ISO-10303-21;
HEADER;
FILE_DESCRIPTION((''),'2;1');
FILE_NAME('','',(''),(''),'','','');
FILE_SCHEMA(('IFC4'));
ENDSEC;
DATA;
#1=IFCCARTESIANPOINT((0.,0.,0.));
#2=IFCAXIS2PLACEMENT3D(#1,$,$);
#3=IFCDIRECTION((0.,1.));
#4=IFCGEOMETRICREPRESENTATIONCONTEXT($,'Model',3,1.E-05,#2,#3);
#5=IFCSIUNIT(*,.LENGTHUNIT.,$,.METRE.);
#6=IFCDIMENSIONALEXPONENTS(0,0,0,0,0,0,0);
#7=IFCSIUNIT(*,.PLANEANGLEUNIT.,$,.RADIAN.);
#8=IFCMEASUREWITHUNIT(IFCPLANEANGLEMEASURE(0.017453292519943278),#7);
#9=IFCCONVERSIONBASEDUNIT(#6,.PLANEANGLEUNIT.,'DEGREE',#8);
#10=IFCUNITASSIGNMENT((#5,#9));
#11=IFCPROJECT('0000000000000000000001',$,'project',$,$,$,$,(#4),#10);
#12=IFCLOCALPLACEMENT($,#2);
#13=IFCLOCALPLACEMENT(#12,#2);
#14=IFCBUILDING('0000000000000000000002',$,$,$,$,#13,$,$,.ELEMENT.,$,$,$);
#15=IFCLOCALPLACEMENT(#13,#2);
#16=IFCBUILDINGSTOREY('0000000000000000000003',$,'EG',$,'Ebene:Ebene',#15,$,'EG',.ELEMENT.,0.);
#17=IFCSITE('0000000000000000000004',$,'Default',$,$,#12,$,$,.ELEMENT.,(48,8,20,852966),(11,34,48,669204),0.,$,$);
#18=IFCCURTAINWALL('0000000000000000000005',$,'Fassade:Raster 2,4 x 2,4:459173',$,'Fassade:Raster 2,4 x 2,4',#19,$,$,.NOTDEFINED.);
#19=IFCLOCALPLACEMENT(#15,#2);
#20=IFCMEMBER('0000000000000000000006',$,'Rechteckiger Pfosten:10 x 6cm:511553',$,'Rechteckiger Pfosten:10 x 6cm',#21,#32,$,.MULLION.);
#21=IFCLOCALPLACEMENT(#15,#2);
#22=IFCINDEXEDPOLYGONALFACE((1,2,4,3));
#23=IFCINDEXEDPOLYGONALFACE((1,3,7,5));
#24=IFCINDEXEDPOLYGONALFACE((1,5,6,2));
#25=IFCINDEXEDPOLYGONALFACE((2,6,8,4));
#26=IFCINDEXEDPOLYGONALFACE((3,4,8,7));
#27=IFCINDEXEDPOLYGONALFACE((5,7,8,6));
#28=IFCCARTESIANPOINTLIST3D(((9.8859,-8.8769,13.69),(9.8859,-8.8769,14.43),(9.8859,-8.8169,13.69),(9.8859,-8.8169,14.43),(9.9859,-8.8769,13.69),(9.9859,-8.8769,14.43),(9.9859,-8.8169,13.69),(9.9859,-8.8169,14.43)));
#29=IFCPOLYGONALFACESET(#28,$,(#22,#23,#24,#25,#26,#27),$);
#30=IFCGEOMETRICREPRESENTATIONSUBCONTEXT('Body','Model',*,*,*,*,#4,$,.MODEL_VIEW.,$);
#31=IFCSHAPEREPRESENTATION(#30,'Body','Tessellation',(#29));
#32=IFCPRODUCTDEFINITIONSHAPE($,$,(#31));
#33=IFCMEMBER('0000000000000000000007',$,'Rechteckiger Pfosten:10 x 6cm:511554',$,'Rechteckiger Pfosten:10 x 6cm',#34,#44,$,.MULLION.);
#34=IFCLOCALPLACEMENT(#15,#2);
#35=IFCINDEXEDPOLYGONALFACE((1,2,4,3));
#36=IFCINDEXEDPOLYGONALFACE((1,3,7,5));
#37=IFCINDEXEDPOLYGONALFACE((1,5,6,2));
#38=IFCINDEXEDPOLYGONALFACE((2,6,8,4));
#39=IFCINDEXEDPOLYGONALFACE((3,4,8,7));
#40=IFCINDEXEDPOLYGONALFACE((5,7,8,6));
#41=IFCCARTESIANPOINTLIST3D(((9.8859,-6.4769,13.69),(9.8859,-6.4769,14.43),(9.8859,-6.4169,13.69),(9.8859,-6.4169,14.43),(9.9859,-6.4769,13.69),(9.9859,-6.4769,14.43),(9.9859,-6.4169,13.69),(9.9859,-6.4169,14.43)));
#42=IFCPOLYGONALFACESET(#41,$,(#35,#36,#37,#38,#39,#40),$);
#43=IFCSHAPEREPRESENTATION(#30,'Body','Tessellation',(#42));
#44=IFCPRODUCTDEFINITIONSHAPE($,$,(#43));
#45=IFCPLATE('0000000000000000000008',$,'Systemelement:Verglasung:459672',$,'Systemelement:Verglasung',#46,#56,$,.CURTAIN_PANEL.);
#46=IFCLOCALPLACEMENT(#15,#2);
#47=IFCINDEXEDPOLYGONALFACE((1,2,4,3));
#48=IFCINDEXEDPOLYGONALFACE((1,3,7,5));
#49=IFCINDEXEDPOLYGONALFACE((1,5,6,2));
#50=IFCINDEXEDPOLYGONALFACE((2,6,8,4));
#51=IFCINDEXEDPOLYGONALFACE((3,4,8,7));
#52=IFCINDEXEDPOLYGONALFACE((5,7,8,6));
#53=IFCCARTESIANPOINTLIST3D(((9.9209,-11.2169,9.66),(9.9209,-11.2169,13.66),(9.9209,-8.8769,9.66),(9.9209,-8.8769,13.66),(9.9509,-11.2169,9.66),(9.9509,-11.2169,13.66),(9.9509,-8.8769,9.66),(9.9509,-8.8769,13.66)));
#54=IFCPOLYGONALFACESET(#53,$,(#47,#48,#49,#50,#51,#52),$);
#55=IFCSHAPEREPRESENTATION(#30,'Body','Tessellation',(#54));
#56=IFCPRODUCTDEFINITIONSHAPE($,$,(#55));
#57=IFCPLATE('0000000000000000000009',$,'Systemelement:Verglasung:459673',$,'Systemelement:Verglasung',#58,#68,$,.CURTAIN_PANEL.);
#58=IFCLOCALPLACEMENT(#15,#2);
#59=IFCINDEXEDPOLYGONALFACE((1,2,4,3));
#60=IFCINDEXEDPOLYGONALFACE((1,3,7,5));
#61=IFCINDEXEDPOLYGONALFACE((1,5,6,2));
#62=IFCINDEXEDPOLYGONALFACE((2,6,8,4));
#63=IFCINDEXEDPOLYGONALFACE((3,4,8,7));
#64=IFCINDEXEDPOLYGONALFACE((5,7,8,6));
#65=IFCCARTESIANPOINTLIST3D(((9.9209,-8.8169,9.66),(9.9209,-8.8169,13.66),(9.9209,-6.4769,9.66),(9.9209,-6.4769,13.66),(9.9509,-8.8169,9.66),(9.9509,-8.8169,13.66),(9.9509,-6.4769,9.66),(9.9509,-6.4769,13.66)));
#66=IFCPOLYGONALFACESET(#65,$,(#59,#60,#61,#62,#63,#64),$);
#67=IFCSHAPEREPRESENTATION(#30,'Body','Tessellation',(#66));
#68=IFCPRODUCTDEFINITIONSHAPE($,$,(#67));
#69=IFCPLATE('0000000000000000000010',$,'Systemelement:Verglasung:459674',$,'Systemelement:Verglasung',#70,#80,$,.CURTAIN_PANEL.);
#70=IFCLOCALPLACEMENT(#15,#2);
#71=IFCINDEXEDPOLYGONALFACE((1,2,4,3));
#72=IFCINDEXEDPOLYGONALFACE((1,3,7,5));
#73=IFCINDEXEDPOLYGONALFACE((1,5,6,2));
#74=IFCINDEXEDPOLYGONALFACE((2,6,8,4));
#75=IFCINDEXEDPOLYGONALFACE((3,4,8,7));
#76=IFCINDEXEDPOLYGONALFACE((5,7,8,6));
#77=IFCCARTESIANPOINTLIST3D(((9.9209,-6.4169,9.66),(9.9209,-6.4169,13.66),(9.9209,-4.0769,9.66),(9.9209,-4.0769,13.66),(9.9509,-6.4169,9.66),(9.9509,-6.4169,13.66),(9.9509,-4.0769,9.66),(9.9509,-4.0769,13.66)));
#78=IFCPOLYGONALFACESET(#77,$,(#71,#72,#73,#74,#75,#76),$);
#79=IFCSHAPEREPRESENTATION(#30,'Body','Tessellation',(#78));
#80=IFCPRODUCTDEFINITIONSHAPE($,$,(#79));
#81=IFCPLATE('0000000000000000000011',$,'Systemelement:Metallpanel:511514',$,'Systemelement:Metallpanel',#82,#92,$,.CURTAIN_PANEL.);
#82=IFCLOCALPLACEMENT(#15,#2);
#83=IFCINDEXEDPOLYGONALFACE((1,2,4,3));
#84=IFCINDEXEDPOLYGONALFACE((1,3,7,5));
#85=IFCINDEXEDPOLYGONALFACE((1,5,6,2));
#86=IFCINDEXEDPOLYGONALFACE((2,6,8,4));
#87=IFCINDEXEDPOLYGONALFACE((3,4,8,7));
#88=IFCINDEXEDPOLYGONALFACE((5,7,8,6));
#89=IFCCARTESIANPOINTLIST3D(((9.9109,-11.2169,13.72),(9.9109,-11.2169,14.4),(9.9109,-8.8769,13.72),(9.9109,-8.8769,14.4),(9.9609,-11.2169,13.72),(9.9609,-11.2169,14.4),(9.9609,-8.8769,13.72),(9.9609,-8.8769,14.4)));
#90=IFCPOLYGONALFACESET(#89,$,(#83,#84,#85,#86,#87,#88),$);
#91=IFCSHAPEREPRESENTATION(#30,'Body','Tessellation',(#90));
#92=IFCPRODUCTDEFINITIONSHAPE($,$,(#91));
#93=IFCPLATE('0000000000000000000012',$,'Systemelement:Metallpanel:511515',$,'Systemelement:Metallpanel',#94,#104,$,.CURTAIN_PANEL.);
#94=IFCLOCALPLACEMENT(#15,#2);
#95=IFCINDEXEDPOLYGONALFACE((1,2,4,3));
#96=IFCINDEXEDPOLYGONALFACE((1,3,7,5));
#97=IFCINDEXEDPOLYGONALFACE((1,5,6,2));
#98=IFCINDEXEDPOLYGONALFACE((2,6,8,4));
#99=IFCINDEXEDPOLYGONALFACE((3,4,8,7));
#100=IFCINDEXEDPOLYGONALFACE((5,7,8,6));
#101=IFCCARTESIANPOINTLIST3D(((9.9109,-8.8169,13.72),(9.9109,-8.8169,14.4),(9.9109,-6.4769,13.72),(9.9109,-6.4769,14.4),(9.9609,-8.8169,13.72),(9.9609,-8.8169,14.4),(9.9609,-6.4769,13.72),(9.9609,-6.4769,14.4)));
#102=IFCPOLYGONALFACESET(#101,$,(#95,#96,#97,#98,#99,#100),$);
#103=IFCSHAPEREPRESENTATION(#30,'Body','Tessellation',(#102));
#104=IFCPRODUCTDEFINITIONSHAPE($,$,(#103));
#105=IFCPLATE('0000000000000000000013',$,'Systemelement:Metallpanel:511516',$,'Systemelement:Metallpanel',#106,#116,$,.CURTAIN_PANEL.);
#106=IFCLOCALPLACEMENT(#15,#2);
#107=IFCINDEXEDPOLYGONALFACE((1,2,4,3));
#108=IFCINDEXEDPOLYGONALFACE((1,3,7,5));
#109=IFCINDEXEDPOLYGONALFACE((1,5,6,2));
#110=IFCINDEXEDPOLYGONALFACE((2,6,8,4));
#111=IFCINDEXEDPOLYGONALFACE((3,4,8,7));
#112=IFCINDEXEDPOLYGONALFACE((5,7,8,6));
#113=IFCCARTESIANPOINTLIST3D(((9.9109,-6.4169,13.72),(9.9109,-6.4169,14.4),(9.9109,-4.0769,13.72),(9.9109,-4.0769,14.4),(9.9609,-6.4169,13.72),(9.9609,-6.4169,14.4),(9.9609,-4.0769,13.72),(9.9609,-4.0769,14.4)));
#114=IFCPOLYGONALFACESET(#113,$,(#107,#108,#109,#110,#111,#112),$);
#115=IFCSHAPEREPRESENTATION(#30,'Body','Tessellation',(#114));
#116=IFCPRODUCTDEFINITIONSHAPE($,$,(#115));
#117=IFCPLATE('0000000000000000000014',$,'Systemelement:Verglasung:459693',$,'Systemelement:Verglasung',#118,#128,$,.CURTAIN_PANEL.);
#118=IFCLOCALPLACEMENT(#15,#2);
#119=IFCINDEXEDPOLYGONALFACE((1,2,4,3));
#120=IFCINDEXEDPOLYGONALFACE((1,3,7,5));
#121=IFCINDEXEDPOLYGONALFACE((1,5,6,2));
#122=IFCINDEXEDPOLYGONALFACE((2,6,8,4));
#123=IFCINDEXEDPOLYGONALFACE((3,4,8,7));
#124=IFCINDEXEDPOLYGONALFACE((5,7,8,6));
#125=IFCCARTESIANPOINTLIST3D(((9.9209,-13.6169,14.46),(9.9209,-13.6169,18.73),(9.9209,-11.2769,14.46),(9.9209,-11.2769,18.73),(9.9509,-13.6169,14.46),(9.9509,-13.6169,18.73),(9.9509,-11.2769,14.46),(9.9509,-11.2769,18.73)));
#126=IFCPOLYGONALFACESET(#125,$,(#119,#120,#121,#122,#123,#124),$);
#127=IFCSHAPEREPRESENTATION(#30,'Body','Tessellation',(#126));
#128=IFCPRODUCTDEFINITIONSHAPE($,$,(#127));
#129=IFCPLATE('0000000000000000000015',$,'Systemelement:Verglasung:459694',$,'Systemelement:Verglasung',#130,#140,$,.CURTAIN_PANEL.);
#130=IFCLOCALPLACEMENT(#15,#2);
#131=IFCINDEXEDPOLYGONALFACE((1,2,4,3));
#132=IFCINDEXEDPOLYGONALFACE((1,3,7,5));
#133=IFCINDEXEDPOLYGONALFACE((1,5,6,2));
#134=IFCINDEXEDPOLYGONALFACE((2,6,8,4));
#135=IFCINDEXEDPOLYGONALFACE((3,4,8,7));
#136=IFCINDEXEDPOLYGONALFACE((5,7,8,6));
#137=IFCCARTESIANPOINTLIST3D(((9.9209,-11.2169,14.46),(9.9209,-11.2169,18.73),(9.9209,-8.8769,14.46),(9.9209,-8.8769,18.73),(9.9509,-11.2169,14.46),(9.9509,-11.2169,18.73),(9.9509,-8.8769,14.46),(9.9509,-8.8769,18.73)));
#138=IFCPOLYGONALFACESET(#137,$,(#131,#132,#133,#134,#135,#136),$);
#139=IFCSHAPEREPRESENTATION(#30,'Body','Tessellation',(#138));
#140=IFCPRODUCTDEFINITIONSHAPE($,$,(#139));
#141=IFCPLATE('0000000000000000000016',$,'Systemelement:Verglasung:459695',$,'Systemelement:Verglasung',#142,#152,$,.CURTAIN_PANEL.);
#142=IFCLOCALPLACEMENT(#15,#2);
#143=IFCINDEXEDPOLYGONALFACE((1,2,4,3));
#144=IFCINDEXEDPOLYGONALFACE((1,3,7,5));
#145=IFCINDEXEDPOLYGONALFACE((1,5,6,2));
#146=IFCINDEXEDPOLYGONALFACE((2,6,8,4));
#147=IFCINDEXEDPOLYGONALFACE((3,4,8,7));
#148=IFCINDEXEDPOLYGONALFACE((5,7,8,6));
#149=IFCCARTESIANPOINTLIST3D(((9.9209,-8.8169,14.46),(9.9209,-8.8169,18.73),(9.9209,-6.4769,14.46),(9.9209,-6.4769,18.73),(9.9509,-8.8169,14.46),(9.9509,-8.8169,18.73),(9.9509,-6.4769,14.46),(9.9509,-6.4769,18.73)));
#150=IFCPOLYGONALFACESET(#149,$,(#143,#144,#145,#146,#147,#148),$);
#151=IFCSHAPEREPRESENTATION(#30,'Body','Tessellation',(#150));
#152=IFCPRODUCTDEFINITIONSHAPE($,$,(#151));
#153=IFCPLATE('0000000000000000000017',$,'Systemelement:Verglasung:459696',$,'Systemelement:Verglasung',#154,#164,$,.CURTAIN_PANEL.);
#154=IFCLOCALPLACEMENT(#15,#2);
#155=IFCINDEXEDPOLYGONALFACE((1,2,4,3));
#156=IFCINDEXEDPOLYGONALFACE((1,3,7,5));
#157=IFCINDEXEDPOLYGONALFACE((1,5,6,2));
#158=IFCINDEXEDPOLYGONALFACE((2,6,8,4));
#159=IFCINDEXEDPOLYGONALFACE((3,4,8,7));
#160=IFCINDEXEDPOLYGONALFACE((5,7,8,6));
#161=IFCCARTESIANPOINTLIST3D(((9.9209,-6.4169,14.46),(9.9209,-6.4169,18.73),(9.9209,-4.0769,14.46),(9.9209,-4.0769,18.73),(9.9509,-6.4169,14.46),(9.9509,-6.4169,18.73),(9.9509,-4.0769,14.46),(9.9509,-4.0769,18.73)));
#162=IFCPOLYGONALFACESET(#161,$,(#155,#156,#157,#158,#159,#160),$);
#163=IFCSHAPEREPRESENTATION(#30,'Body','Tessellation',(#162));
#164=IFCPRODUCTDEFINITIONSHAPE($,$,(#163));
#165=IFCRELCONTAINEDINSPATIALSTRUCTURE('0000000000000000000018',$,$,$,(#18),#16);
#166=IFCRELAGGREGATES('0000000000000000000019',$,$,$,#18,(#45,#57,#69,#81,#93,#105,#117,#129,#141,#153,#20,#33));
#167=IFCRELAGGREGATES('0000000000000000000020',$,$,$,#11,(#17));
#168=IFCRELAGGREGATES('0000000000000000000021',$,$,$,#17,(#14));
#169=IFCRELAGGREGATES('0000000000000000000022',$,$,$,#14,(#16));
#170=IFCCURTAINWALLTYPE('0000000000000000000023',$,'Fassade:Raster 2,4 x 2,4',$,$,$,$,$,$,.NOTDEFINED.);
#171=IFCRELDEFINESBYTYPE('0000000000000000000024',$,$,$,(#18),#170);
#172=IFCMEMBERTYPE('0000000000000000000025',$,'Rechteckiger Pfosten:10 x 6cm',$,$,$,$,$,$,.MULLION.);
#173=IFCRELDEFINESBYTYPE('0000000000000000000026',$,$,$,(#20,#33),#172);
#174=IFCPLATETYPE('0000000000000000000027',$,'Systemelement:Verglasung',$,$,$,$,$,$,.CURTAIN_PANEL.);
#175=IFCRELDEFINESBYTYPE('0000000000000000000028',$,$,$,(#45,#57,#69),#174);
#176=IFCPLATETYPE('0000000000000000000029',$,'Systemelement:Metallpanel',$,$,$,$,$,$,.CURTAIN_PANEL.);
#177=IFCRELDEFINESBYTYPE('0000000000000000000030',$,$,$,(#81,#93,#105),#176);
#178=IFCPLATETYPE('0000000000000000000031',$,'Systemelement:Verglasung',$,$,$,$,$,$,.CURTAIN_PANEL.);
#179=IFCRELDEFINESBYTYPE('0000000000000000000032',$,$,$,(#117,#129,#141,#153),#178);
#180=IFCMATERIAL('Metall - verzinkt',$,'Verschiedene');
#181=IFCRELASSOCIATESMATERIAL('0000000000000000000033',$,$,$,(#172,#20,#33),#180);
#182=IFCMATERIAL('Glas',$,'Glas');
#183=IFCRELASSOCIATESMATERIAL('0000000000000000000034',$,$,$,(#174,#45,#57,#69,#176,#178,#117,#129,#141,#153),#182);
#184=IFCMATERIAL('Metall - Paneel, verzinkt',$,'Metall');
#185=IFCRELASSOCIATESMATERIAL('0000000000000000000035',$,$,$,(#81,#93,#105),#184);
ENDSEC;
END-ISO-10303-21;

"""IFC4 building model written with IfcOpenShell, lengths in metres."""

from ifc_helpers import new_model, entity, si_unit, converted_unit, direction, frame, origin, place, context, subcontext, project, spatial, indexed_curve, outline, extrude, source, transform, mapped, material, type_object, type_shapes, element, aggregate, save


model = new_model("IFC4")

# Units and contexts
model_context = context("Model", 3, precision=1e-05, world=origin(), true_north=direction((0.0, 1.0)))
body_context = subcontext(model_context, "Body", "Model", "MODEL_VIEW")
ifc_project = project(units=[si_unit("LENGTHUNIT", "METRE"), converted_unit("PLANEANGLEUNIT", "DEGREE", entity("IfcPlaneAngleMeasure", 0.017453292519943278), si_unit("PLANEANGLEUNIT", "RADIAN"), dimensions=[0, 0, 0, 0, 0, 0, 0])], contexts=[model_context])

# Site, building, storey
site_placement = place(None, origin())
site = spatial("IfcSite", under=ifc_project, at=site_placement, Name="Default", CompositionType="ELEMENT", RefLatitude=(48, 8, 20, 852966), RefLongitude=(11, 34, 48, 669204), RefElevation=0.0)
building_placement = place(site_placement, origin())
building = spatial("IfcBuilding", under=site, at=building_placement, CompositionType="ELEMENT")
storey_placement = place(building_placement, origin())
storey = spatial("IfcBuildingStorey", under=building, at=storey_placement, Name="EG", ObjectType="Ebene:Ebene", LongName="EG", CompositionType="ELEMENT", Elevation=0.0)

# Curtain wall, members, plates
curtain_wall_type = type_object("IfcCurtainWallType", Name="Fassade:Raster 2,4 x 2,4", PredefinedType="NOTDEFINED")
curtain_wall_placement = place(storey_placement, origin())
curtain_wall = element("IfcCurtainWall", 1, at=curtain_wall_placement, inside=storey, type_object=curtain_wall_type, Name="Fassade:Raster 2,4 x 2,4:459173", ObjectType="Fassade:Raster 2,4 x 2,4", PredefinedType="NOTDEFINED")
ifc_material_1 = material(Name="Metall - verzinkt", Category="Verschiedene")
member_type_1 = type_object("IfcMemberType", Name="Rechteckiger Pfosten:10 x 6cm", PredefinedType="MULLION", material=ifc_material_1)
shared_shape_1 = source(origin(), body_context, "Body", "SweptSolid", [
    extrude(outline(indexed_curve([(-0.03, -0.05), (0.03, -0.05), (0.03, 0.05), (-0.03, 0.05), (-0.03, -0.05)], self_intersect=False)), frame((0.0, 0.0, -0.74), z_axis=(0.0, 0.0, 1.0), x_axis=(-1.0, 0.0, 0.0)), (0.0, 0.0, 1.0), 0.74),
])
type_shapes(member_type_1, [shared_shape_1])
member_1_placement = place(curtain_wall_placement, frame((9.9359, -8.8469, 13.69), z_axis=(0.0, 0.0, -1.0), x_axis=(0.0, 1.0, 0.0)))
member_1 = element("IfcMember", 2, at=member_1_placement, type_object=member_type_1, material=ifc_material_1, Name="Rechteckiger Pfosten:10 x 6cm:511553", ObjectType="Rechteckiger Pfosten:10 x 6cm", PredefinedType="MULLION", context=body_context, shape_type="MappedRepresentation", body=[
    mapped(shared_shape_1, transform((0.0, 0.0, 0.0), scale=1.0)),
])
member_2_placement = place(curtain_wall_placement, frame((9.9359, -6.4469, 13.69), z_axis=(0.0, 0.0, -1.0), x_axis=(0.0, 1.0, 0.0)))
member_2 = element("IfcMember", 3, at=member_2_placement, type_object=member_type_1, material=ifc_material_1, Name="Rechteckiger Pfosten:10 x 6cm:511554", ObjectType="Rechteckiger Pfosten:10 x 6cm", PredefinedType="MULLION", context=body_context, shape_type="MappedRepresentation", body=[
    mapped(shared_shape_1, transform((0.0, 0.0, 0.0), scale=1.0)),
])
ifc_material_2 = material(Name="Glas", Category="Glas")
plate_type_1 = type_object("IfcPlateType", Name="Systemelement:Verglasung", PredefinedType="CURTAIN_PANEL", material=ifc_material_2)
shared_shape_2 = source(origin(), body_context, "Body", "SweptSolid", [
    extrude(outline(indexed_curve([(-0.015, -1.17), (0.015, -1.17), (0.015, 1.17), (-0.015, 1.17), (-0.015, -1.17)], self_intersect=False)), frame((0.0, 0.0, 0.0), z_axis=(0.0, 0.0, 1.0), x_axis=(0.0, 1.0, 0.0)), (0.0, 0.0, 1.0), 4.0),
])
type_shapes(plate_type_1, [shared_shape_2])
plate_1_placement = place(curtain_wall_placement, frame((9.9359, -10.0469, 9.66), z_axis=(0.0, 0.0, 1.0), x_axis=(0.0, 1.0, 0.0)))
plate_1 = element("IfcPlate", 4, at=plate_1_placement, type_object=plate_type_1, material=ifc_material_2, Name="Systemelement:Verglasung:459672", ObjectType="Systemelement:Verglasung", PredefinedType="CURTAIN_PANEL", context=body_context, shape_type="MappedRepresentation", body=[
    mapped(shared_shape_2, transform((0.0, 0.0, 0.0), scale=1.0)),
])
plate_2_placement = place(curtain_wall_placement, frame((9.9359, -7.6469, 9.66), z_axis=(0.0, 0.0, 1.0), x_axis=(0.0, 1.0, 0.0)))
plate_2 = element("IfcPlate", 5, at=plate_2_placement, type_object=plate_type_1, material=ifc_material_2, Name="Systemelement:Verglasung:459673", ObjectType="Systemelement:Verglasung", PredefinedType="CURTAIN_PANEL", context=body_context, shape_type="MappedRepresentation", body=[
    mapped(shared_shape_2, transform((0.0, 0.0, 0.0), scale=1.0)),
])
plate_3_placement = place(curtain_wall_placement, frame((9.9359, -5.2469, 9.66), z_axis=(0.0, 0.0, 1.0), x_axis=(0.0, 1.0, 0.0)))
plate_3 = element("IfcPlate", 6, at=plate_3_placement, type_object=plate_type_1, material=ifc_material_2, Name="Systemelement:Verglasung:459674", ObjectType="Systemelement:Verglasung", PredefinedType="CURTAIN_PANEL", context=body_context, shape_type="MappedRepresentation", body=[
    mapped(shared_shape_2, transform((0.0, 0.0, 0.0), scale=1.0)),
])
ifc_material_3 = material(Name="Metall - Paneel, verzinkt", Category="Metall")
plate_type_2 = type_object("IfcPlateType", Name="Systemelement:Metallpanel", PredefinedType="CURTAIN_PANEL", material=ifc_material_2)
shared_shape_3 = source(origin(), body_context, "Body", "SweptSolid", [
    extrude(outline(indexed_curve([(-0.025, -1.17), (0.025, -1.17), (0.025, 1.17), (-0.025, 1.17), (-0.025, -1.17)], self_intersect=False)), frame((0.0, 0.0, 0.0), z_axis=(0.0, 0.0, 1.0), x_axis=(0.0, 1.0, 0.0)), (0.0, 0.0, 1.0), 0.68),
])
type_shapes(plate_type_2, [shared_shape_3])
plate_4_placement = place(curtain_wall_placement, frame((9.9359, -10.0469, 13.72), z_axis=(0.0, 0.0, 1.0), x_axis=(0.0, 1.0, 0.0)))
plate_4 = element("IfcPlate", 7, at=plate_4_placement, type_object=plate_type_2, material=ifc_material_3, Name="Systemelement:Metallpanel:511514", ObjectType="Systemelement:Metallpanel", PredefinedType="CURTAIN_PANEL", context=body_context, shape_type="MappedRepresentation", body=[
    mapped(shared_shape_3, transform((0.0, 0.0, 0.0), scale=1.0)),
])
plate_5_placement = place(curtain_wall_placement, frame((9.9359, -7.6469, 13.72), z_axis=(0.0, 0.0, 1.0), x_axis=(0.0, 1.0, 0.0)))
plate_5 = element("IfcPlate", 8, at=plate_5_placement, type_object=plate_type_2, material=ifc_material_3, Name="Systemelement:Metallpanel:511515", ObjectType="Systemelement:Metallpanel", PredefinedType="CURTAIN_PANEL", context=body_context, shape_type="MappedRepresentation", body=[
    mapped(shared_shape_3, transform((0.0, 0.0, 0.0), scale=1.0)),
])
plate_6_placement = place(curtain_wall_placement, frame((9.9359, -5.2469, 13.72), z_axis=(0.0, 0.0, 1.0), x_axis=(0.0, 1.0, 0.0)))
plate_6 = element("IfcPlate", 9, at=plate_6_placement, type_object=plate_type_2, material=ifc_material_3, Name="Systemelement:Metallpanel:511516", ObjectType="Systemelement:Metallpanel", PredefinedType="CURTAIN_PANEL", context=body_context, shape_type="MappedRepresentation", body=[
    mapped(shared_shape_3, transform((0.0, 0.0, 0.0), scale=1.0)),
])
plate_type_3 = type_object("IfcPlateType", Name="Systemelement:Verglasung", PredefinedType="CURTAIN_PANEL", material=ifc_material_2)
shared_shape_4 = source(origin(), body_context, "Body", "SweptSolid", [
    extrude(outline(indexed_curve([(-0.015, -1.17), (0.015, -1.17), (0.015, 1.17), (-0.015, 1.17), (-0.015, -1.17)], self_intersect=False)), frame((0.0, 0.0, 0.0), z_axis=(0.0, 0.0, 1.0), x_axis=(0.0, 1.0, 0.0)), (0.0, 0.0, 1.0), 4.27),
])
type_shapes(plate_type_3, [shared_shape_4])
plate_7_placement = place(curtain_wall_placement, frame((9.9359, -12.4469, 14.46), z_axis=(0.0, 0.0, 1.0), x_axis=(0.0, 1.0, 0.0)))
plate_7 = element("IfcPlate", 10, at=plate_7_placement, type_object=plate_type_3, material=ifc_material_2, Name="Systemelement:Verglasung:459693", ObjectType="Systemelement:Verglasung", PredefinedType="CURTAIN_PANEL", context=body_context, shape_type="MappedRepresentation", body=[
    mapped(shared_shape_4, transform((0.0, 0.0, 0.0), scale=1.0)),
])
plate_8_placement = place(curtain_wall_placement, frame((9.9359, -10.0469, 14.46), z_axis=(0.0, 0.0, 1.0), x_axis=(0.0, 1.0, 0.0)))
plate_8 = element("IfcPlate", 11, at=plate_8_placement, type_object=plate_type_3, material=ifc_material_2, Name="Systemelement:Verglasung:459694", ObjectType="Systemelement:Verglasung", PredefinedType="CURTAIN_PANEL", context=body_context, shape_type="MappedRepresentation", body=[
    mapped(shared_shape_4, transform((0.0, 0.0, 0.0), scale=1.0)),
])
plate_9_placement = place(curtain_wall_placement, frame((9.9359, -7.6469, 14.46), z_axis=(0.0, 0.0, 1.0), x_axis=(0.0, 1.0, 0.0)))
plate_9 = element("IfcPlate", 12, at=plate_9_placement, type_object=plate_type_3, material=ifc_material_2, Name="Systemelement:Verglasung:459695", ObjectType="Systemelement:Verglasung", PredefinedType="CURTAIN_PANEL", context=body_context, shape_type="MappedRepresentation", body=[
    mapped(shared_shape_4, transform((0.0, 0.0, 0.0), scale=1.0)),
])
plate_10_placement = place(curtain_wall_placement, frame((9.9359, -5.2469, 14.46), z_axis=(0.0, 0.0, 1.0), x_axis=(0.0, 1.0, 0.0)))
plate_10 = element("IfcPlate", 13, at=plate_10_placement, type_object=plate_type_3, material=ifc_material_2, Name="Systemelement:Verglasung:459696", ObjectType="Systemelement:Verglasung", PredefinedType="CURTAIN_PANEL", context=body_context, shape_type="MappedRepresentation", body=[
    mapped(shared_shape_4, transform((0.0, 0.0, 0.0), scale=1.0)),
])
aggregate(curtain_wall, [plate_1, plate_2, plate_3, plate_4, plate_5, plate_6, plate_7, plate_8, plate_9, plate_10, member_1, member_2])

save(model, "model.ifc")
